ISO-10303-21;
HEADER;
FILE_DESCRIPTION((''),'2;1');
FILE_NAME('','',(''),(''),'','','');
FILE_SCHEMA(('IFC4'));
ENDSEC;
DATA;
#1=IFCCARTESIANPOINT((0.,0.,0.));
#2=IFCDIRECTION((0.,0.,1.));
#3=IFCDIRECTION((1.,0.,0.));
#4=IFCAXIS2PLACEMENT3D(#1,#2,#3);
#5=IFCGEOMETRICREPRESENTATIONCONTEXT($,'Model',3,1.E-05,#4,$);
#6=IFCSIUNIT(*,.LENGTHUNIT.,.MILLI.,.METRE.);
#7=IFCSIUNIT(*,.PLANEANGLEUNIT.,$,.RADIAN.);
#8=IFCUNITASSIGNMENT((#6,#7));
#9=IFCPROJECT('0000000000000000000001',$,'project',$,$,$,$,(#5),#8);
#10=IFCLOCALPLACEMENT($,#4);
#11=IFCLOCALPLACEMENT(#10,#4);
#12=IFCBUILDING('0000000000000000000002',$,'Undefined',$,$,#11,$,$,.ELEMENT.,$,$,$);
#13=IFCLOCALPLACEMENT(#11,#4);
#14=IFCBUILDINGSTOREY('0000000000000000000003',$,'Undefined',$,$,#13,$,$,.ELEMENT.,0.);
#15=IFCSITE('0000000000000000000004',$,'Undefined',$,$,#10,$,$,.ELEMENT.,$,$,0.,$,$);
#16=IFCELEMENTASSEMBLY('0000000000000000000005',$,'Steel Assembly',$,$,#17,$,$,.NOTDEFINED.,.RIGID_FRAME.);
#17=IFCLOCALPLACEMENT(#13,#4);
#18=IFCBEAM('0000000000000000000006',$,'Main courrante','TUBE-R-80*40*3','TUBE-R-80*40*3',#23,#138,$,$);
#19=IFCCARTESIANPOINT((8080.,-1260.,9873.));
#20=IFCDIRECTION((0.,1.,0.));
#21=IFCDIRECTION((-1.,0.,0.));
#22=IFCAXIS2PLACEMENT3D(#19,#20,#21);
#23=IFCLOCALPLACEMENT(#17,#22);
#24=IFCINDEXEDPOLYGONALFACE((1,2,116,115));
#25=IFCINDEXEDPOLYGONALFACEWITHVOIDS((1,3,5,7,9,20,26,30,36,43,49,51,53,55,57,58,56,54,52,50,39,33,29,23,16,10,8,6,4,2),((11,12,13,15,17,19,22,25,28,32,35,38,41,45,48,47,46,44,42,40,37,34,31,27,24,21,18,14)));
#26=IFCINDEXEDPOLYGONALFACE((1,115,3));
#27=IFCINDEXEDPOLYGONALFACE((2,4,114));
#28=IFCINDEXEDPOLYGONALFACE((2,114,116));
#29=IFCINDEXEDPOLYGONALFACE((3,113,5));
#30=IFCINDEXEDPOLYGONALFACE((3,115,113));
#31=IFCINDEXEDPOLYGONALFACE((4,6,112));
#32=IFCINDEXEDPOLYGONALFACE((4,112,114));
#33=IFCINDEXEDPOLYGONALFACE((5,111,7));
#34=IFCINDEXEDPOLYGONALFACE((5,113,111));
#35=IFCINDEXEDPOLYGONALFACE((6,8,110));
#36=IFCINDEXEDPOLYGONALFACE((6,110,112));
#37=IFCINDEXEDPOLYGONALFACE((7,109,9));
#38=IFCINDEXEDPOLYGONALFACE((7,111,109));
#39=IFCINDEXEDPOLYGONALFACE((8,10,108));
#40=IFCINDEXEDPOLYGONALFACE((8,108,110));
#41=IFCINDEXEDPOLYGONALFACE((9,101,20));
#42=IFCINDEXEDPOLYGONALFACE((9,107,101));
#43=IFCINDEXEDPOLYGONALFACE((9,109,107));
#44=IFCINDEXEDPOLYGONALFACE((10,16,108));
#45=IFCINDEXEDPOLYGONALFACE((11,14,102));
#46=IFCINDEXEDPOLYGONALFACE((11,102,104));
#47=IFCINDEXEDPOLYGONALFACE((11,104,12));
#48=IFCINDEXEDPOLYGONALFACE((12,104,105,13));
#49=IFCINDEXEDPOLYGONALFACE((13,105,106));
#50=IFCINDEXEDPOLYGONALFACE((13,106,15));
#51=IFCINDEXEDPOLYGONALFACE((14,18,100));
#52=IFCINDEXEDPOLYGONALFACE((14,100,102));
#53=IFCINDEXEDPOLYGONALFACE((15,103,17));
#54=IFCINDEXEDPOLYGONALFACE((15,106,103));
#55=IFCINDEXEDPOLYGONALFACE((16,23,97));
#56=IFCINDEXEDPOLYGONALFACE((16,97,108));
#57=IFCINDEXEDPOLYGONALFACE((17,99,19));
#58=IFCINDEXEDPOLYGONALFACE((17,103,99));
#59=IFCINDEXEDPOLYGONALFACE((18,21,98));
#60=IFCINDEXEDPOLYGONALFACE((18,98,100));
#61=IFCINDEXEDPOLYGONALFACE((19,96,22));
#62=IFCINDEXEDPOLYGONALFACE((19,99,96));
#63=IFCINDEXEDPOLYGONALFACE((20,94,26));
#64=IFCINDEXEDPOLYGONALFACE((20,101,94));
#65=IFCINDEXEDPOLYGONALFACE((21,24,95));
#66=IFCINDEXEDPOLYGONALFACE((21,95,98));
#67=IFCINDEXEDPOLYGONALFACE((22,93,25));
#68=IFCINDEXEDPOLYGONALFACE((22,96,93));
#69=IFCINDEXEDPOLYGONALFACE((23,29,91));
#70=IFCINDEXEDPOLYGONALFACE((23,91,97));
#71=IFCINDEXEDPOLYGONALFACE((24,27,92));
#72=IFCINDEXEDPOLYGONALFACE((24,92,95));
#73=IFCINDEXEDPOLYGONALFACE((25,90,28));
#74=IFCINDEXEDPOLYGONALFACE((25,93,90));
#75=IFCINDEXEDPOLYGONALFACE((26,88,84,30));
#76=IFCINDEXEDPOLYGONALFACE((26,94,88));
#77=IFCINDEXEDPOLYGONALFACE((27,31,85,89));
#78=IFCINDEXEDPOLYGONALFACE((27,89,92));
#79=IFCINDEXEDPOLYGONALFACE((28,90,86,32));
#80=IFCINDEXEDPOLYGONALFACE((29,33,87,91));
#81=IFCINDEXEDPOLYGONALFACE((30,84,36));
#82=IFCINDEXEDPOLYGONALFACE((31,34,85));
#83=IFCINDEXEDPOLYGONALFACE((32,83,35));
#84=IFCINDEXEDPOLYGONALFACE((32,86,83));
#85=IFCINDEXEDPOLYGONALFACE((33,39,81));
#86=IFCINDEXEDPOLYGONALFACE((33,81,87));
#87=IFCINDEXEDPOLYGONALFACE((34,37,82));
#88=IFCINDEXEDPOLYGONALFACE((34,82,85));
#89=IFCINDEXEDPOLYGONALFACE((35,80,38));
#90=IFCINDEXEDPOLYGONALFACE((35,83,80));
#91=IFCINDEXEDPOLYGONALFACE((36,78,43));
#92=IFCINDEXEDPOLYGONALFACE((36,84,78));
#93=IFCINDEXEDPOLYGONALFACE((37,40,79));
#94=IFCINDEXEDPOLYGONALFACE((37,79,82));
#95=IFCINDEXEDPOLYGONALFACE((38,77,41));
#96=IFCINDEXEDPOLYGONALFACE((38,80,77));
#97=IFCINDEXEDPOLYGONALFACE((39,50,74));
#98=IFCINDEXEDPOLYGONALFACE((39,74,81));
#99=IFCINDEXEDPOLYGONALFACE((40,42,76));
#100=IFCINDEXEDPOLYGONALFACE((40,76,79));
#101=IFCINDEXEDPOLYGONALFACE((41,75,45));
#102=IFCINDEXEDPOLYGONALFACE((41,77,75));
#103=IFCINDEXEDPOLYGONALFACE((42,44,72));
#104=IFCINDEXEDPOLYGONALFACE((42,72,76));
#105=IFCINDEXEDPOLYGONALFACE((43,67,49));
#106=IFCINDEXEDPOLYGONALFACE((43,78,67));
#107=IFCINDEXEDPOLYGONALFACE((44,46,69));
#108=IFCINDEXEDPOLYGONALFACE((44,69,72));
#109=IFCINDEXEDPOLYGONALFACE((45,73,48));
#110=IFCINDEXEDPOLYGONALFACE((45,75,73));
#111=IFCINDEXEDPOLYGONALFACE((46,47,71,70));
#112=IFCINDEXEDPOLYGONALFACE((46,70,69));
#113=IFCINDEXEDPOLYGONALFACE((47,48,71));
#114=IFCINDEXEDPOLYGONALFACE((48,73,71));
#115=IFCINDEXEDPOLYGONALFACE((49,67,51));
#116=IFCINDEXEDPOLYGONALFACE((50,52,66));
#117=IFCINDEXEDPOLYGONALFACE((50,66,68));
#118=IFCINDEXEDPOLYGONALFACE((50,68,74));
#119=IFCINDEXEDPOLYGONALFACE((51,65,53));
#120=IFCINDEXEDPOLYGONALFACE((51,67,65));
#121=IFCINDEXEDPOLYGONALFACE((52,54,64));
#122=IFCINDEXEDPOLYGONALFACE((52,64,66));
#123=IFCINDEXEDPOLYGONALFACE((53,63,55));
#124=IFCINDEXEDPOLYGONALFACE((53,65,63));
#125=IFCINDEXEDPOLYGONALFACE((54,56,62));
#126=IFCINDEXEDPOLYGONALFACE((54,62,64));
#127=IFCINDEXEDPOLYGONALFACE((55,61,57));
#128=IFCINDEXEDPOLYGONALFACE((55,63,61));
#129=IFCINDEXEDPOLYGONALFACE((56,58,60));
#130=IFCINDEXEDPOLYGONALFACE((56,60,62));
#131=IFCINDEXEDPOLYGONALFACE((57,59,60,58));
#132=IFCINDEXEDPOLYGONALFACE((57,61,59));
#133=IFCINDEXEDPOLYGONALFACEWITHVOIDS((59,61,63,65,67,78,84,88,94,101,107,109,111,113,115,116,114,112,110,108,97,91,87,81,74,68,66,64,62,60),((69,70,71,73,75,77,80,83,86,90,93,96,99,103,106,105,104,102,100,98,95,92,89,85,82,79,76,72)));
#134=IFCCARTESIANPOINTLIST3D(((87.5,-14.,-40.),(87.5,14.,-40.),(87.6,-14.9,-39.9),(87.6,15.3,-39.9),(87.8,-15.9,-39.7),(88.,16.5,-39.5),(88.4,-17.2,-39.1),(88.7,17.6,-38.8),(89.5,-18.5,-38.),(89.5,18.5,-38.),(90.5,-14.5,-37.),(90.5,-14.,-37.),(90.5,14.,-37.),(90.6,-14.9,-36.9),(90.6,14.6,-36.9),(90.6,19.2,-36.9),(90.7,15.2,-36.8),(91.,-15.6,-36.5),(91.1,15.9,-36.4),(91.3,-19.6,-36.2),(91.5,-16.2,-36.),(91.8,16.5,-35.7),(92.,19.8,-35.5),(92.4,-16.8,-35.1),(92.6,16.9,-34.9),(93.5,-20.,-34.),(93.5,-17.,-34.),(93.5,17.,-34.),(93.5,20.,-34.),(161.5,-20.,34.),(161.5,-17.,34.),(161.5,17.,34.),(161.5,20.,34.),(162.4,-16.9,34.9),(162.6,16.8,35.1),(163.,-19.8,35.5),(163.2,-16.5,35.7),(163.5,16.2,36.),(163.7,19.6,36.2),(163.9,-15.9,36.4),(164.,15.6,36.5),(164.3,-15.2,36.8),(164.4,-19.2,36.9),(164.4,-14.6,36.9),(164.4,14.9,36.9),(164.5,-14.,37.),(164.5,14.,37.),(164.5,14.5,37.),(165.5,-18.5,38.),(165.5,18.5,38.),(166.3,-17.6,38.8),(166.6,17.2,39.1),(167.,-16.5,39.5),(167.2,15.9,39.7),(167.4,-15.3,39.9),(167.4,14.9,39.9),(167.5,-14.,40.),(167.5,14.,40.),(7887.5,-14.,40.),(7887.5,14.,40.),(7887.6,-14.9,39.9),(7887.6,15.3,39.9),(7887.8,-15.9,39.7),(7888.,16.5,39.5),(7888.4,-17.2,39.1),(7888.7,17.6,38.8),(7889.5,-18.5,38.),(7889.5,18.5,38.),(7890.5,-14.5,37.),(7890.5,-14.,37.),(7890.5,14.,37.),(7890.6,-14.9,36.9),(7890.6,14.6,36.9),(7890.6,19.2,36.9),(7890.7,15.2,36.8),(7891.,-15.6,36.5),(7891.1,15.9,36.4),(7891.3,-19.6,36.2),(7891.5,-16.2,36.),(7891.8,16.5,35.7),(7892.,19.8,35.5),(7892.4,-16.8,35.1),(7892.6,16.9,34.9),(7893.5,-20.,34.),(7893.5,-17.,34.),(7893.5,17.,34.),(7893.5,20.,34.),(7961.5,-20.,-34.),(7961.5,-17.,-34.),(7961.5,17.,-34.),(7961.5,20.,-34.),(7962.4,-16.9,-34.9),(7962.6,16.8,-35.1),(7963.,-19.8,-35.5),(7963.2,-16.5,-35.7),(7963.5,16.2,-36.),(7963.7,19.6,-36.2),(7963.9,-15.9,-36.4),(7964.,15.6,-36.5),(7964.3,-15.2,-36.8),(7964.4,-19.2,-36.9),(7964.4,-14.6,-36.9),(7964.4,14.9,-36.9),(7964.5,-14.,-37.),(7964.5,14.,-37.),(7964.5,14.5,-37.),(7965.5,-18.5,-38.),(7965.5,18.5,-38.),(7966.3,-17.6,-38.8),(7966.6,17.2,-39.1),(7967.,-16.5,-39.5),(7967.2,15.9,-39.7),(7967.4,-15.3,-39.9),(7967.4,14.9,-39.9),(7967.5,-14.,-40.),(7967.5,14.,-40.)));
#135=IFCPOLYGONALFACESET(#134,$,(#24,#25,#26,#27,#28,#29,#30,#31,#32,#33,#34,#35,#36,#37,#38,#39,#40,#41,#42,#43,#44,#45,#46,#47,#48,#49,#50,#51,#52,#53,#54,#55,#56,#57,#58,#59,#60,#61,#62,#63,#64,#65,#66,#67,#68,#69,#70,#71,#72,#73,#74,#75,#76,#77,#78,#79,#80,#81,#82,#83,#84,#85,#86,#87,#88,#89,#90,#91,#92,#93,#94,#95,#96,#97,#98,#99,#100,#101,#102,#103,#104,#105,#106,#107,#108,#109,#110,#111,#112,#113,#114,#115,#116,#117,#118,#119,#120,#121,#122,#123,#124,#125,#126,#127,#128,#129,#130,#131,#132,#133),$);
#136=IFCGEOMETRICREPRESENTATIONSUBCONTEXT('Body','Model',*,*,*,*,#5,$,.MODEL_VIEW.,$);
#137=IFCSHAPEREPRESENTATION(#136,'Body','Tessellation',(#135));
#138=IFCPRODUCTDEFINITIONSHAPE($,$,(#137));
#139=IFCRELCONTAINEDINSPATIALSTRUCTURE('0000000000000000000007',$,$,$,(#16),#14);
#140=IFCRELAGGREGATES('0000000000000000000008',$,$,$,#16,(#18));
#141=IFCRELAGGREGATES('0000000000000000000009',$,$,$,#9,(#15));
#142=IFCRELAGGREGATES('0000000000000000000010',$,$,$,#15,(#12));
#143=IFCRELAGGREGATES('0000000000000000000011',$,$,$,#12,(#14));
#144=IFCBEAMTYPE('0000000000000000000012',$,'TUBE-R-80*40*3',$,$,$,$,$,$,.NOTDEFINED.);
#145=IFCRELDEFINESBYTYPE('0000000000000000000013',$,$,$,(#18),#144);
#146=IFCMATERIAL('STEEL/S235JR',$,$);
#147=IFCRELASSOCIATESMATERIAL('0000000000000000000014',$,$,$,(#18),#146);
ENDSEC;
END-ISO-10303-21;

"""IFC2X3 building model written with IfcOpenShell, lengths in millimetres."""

from ifc_helpers import new_model, si_unit, frame, origin_with_axes, origin_2d_with_axis, place, context, subcontext, project, spatial, hollow_rectangle, extrude, clip, halfspace, material, type_object, element, aggregate, save


model = new_model("IFC2X3")

# Units and contexts
model_context = context("Model", 3, precision=1e-05, world=origin_with_axes())
body_context = subcontext(model_context, "Body", "Model", "MODEL_VIEW")
ifc_project = project(units=[si_unit("LENGTHUNIT", "METRE", prefix="MILLI"), si_unit("PLANEANGLEUNIT", "RADIAN")], contexts=[model_context])

# Site, building, storey
site_placement = place(None, origin_with_axes())
site = spatial("IfcSite", under=ifc_project, at=site_placement, Name="Undefined", CompositionType="ELEMENT", RefElevation=0.0)
building_placement = place(site_placement, origin_with_axes())
building = spatial("IfcBuilding", under=site, at=building_placement, Name="Undefined", CompositionType="ELEMENT")
storey_placement = place(building_placement, origin_with_axes())
storey = spatial("IfcBuildingStorey", under=building, at=storey_placement, Name="Undefined", CompositionType="ELEMENT", Elevation=0.0)

# Element assembly, beam
assembly_1_placement = place(storey_placement, origin_with_axes())
assembly_1 = element("IfcElementAssembly", 1, at=assembly_1_placement, inside=storey, Name="Steel Assembly", AssemblyPlace="NOTDEFINED", PredefinedType="RIGID_FRAME")
ifc_material_1 = material(Name="STEEL/S235JR")
beam_type_1 = type_object("IfcBeamType", Name="TUBE-R-80*40*3", PredefinedType="NOTDEFINED")
beam_1_placement = place(assembly_1_placement, frame((8080.0, -1260.0, 9873.0), z_axis=(0.0, 1.0, 0.0), x_axis=(-1.0, 0.0, 0.0)))
beam_1 = element("IfcBeam", 2, at=beam_1_placement, type_object=beam_type_1, material=ifc_material_1, Name="Main courrante", Description="TUBE-R-80*40*3", ObjectType="TUBE-R-80*40*3", context=body_context, shape_type="Clipping", body=[
    clip(clip(extrude(hollow_rectangle(XDim=40.0, YDim=80.0, WallThickness=3.0, InnerFilletRadius=3.0, OuterFilletRadius=6.0, at=origin_2d_with_axis()), frame((8008.3, 0.0, 0.0), z_axis=(-1.0, 0.0, 0.0), x_axis=(0.0, -1.0, 0.0)), (0.0, 0.0, 1.0), 7961.6), halfspace(frame((7951.1, 0.0, -23.6), z_axis=(-0.707107, 0.0, -0.707107), x_axis=(0.0, 1.0, 0.0)), True)), halfspace(frame((103.9, 0.0, -23.6), z_axis=(0.707107, 0.0, -0.707107), x_axis=(0.707107, 0.0, 0.707107)), True)),
])

aggregate(assembly_1, [beam_1])

save(model, "model.ifc")
